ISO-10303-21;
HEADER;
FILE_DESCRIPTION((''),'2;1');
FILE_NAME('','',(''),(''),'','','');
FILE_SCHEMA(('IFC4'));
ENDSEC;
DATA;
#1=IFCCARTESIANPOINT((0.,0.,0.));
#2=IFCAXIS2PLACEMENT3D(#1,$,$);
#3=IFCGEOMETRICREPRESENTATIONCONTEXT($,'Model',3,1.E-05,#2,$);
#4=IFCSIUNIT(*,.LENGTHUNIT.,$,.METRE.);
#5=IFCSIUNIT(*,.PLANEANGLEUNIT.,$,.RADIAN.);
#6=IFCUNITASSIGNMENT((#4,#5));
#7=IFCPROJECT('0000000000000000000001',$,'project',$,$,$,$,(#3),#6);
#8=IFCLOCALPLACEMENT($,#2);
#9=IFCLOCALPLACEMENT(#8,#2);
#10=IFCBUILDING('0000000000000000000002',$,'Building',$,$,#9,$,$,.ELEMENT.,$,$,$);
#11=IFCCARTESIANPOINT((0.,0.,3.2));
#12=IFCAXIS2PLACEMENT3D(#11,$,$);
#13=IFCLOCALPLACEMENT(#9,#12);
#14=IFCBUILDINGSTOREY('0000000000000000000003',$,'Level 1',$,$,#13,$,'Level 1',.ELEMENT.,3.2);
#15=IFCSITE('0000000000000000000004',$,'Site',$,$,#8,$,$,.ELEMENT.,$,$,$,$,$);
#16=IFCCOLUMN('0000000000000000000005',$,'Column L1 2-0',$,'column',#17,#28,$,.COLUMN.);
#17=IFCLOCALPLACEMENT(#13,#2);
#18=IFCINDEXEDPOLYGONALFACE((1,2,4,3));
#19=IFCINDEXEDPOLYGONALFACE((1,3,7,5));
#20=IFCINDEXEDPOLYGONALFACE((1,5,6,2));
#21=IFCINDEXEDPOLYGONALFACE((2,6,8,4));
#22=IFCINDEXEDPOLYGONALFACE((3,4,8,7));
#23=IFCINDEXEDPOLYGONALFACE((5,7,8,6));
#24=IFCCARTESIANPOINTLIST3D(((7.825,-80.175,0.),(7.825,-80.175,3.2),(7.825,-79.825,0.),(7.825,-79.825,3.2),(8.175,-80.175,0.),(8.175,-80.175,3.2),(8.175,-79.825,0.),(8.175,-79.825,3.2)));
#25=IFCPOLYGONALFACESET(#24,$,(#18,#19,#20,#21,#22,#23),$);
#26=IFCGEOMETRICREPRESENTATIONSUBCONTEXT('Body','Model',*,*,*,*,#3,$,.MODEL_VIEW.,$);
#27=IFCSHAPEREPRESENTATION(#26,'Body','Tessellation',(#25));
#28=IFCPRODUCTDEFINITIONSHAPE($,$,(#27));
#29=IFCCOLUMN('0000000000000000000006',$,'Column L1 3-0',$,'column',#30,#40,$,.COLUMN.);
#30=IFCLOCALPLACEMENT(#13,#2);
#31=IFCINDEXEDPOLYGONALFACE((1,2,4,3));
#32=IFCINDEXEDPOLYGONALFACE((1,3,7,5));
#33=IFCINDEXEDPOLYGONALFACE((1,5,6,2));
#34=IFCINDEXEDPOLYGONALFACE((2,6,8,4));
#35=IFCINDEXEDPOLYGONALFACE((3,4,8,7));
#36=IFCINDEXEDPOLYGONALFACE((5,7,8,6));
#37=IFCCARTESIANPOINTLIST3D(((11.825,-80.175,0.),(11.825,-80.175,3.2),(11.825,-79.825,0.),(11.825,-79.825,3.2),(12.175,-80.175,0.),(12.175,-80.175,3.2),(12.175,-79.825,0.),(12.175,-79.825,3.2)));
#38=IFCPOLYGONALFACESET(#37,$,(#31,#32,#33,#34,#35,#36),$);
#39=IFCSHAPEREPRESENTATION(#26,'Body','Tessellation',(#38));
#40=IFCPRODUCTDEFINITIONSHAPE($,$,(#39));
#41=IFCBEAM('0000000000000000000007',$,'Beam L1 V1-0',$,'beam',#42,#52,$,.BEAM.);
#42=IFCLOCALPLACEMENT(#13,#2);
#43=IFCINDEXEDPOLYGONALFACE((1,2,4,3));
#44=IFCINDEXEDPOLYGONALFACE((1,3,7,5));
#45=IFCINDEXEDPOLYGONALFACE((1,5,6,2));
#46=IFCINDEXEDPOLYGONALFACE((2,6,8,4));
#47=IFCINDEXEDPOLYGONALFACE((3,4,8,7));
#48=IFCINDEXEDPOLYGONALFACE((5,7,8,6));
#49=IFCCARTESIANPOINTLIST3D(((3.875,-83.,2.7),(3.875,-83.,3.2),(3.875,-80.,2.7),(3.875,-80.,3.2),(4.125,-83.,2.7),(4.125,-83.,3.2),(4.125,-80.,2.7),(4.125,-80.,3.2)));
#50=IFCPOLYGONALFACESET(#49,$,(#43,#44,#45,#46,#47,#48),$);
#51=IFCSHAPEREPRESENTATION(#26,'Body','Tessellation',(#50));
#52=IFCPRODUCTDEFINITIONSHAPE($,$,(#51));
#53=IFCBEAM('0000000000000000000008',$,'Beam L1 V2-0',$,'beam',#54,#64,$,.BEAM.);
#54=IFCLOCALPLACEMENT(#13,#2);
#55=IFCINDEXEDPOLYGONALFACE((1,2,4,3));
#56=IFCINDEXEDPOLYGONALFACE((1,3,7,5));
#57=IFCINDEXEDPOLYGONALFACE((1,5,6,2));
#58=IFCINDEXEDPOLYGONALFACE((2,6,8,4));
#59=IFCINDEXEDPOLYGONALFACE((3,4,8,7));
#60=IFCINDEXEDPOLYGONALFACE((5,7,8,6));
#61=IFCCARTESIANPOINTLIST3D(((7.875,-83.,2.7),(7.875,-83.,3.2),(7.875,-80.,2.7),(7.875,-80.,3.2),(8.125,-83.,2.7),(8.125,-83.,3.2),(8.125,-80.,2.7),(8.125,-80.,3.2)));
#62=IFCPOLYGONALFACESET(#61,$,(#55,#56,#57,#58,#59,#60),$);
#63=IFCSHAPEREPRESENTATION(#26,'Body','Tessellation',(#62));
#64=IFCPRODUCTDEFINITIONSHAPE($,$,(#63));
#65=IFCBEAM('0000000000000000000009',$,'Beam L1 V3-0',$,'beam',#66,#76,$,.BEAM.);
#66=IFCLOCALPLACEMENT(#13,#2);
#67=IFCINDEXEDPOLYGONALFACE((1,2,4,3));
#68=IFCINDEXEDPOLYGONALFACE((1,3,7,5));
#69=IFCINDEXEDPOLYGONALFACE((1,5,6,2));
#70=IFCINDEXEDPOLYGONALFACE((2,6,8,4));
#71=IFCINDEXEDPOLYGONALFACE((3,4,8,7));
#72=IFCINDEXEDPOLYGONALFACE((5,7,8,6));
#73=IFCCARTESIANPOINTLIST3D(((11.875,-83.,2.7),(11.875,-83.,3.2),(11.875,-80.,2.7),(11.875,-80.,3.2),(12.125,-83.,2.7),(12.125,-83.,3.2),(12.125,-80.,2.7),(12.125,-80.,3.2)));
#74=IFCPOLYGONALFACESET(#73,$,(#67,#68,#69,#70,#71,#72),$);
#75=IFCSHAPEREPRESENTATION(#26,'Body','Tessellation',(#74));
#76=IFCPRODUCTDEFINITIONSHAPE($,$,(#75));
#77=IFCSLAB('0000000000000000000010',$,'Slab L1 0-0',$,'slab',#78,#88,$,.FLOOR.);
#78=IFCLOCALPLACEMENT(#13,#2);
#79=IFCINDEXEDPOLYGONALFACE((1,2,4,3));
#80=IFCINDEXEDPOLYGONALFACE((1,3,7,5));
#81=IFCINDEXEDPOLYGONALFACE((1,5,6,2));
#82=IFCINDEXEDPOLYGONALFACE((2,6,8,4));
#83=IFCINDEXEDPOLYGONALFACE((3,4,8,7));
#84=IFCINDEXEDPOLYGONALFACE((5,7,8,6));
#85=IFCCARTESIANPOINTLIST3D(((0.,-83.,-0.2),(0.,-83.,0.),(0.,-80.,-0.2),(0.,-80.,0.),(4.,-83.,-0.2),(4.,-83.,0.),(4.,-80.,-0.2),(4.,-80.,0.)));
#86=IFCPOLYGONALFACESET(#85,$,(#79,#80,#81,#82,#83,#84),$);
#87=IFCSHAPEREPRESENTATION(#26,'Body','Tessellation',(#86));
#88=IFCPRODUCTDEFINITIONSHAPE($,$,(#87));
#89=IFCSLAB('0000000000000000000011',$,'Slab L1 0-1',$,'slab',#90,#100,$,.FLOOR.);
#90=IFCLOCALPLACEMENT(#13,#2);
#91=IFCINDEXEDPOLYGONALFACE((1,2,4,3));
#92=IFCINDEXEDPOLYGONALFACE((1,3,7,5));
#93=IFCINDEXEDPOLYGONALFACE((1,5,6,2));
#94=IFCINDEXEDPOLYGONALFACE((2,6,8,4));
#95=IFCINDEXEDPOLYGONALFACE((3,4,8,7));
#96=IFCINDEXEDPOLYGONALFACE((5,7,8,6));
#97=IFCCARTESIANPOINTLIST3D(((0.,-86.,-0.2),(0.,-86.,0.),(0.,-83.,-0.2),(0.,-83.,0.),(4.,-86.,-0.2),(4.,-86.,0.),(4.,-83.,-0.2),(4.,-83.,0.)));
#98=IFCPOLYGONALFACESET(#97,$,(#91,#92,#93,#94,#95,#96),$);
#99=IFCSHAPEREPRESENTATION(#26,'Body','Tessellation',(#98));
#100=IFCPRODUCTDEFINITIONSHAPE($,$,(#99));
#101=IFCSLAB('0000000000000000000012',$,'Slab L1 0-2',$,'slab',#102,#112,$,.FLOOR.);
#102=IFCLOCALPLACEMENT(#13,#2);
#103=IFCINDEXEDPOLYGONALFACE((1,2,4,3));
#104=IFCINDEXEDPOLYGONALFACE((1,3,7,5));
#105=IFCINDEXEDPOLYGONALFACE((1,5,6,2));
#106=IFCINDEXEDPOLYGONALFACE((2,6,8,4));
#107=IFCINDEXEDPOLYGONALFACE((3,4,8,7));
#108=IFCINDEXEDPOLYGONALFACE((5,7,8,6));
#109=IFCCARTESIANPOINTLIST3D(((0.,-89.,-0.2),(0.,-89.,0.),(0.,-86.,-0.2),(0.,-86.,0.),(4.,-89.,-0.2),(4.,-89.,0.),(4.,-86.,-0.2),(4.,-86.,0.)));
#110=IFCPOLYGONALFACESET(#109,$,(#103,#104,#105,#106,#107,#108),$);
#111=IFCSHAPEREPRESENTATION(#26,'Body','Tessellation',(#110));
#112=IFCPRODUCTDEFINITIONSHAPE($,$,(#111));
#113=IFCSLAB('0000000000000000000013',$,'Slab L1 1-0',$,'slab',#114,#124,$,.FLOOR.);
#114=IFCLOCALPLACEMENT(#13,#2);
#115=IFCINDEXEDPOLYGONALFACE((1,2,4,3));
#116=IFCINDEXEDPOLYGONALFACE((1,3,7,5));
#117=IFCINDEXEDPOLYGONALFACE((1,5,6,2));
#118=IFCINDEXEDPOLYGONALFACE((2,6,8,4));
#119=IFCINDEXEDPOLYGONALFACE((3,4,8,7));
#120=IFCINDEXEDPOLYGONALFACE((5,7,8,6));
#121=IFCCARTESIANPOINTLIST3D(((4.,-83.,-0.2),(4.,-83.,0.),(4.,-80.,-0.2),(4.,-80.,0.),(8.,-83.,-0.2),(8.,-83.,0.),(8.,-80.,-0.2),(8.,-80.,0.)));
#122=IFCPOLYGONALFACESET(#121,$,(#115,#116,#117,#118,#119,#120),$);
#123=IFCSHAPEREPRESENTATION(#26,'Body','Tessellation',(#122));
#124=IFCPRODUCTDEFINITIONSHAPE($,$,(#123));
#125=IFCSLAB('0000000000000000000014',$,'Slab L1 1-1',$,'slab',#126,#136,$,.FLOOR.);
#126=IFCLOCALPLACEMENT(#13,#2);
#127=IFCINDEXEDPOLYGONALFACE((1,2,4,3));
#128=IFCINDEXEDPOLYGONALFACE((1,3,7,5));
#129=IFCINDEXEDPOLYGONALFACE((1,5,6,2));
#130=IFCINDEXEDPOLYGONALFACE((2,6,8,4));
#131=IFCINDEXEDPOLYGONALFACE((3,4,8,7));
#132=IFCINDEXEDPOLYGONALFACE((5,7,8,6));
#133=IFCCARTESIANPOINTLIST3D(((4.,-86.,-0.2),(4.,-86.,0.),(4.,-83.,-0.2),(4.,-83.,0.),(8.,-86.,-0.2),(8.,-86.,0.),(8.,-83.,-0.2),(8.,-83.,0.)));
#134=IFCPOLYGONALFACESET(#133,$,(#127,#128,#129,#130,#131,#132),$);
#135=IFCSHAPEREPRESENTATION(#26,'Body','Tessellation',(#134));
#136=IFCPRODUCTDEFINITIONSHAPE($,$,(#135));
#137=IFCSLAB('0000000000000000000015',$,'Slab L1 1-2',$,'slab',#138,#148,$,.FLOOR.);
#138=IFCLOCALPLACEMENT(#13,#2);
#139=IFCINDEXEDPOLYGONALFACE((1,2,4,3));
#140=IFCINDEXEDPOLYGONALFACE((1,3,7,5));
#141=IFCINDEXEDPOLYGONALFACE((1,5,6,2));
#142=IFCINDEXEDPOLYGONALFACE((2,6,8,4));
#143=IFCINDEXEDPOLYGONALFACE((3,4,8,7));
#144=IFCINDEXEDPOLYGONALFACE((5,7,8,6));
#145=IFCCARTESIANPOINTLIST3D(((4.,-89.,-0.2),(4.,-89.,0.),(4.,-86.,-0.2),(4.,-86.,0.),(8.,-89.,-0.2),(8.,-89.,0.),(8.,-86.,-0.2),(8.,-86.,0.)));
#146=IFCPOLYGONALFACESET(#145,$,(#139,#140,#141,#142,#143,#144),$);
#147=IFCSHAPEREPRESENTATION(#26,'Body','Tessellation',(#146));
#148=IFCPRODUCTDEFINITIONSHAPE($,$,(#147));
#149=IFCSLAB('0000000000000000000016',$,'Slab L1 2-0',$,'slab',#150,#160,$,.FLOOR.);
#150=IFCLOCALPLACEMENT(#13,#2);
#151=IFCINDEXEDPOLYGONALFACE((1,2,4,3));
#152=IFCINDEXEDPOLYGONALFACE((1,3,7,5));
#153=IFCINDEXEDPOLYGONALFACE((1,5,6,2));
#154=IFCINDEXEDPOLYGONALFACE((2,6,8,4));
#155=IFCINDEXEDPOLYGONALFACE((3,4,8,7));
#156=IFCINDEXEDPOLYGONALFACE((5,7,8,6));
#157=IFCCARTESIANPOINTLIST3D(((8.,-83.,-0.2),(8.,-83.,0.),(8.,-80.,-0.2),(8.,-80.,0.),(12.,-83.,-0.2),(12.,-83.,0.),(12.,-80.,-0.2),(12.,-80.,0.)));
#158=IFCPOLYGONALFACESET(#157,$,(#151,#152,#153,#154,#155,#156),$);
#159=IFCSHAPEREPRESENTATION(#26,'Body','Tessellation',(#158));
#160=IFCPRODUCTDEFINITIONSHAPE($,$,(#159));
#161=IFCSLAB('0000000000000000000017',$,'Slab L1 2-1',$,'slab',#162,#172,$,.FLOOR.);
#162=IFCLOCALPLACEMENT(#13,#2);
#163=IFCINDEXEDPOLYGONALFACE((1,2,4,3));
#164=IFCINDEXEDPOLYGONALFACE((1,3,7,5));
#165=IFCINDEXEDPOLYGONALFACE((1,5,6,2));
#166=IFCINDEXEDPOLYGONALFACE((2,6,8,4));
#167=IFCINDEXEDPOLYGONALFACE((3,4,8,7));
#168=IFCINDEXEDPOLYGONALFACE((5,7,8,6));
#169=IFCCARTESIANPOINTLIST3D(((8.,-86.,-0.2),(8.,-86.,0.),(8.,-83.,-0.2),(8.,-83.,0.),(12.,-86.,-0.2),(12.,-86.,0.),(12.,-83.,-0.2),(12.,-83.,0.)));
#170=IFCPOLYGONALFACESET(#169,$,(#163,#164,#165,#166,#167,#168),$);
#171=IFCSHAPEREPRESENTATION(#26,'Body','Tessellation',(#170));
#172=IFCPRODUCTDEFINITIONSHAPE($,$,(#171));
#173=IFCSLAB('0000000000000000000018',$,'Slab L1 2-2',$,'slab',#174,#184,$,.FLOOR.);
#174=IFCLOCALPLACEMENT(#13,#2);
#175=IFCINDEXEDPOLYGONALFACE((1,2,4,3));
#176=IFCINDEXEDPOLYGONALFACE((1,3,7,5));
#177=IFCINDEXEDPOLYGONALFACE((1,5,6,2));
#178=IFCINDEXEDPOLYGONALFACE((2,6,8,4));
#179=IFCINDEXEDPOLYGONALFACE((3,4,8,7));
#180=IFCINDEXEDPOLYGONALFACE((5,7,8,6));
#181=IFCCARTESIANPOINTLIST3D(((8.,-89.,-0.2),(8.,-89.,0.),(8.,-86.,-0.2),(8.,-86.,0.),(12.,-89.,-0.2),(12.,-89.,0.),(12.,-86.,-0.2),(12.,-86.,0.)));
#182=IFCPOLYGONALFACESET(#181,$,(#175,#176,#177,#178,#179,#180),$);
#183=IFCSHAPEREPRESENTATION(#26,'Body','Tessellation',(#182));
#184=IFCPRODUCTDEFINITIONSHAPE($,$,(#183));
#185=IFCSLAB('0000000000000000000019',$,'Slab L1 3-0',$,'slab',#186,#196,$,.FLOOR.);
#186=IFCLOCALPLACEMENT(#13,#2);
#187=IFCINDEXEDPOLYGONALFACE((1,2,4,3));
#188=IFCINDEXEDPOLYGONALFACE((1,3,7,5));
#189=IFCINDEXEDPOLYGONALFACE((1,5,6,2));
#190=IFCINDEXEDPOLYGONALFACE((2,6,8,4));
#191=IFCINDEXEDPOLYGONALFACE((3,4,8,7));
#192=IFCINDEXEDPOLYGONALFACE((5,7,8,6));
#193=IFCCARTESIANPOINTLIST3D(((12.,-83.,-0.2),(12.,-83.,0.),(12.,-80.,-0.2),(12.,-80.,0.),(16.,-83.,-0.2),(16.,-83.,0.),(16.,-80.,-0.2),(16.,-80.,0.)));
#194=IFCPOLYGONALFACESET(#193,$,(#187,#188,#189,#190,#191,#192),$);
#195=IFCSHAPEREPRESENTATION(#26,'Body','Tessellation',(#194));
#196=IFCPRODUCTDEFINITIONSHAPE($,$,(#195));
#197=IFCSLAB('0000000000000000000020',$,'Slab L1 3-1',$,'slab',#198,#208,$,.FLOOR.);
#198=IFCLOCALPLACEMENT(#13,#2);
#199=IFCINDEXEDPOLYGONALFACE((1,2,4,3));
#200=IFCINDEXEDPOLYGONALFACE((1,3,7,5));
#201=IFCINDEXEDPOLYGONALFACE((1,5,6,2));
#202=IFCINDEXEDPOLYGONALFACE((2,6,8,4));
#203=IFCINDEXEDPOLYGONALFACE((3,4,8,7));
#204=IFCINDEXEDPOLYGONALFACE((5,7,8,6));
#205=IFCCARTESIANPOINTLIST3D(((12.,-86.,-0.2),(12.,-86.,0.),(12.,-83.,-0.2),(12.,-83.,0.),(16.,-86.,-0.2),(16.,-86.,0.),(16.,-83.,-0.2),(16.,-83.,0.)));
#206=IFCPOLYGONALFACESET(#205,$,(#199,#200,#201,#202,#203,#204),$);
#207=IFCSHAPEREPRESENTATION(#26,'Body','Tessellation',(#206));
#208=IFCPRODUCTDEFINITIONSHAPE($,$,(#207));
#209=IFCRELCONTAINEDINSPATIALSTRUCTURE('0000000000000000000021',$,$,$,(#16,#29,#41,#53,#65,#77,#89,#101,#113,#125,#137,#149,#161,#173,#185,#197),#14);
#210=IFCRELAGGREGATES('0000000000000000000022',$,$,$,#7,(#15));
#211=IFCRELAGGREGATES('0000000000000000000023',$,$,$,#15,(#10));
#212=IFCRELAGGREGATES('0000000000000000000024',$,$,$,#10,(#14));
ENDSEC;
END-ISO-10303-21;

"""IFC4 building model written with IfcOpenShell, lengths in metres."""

from ifc_helpers import new_model, si_unit, frame, origin, origin_2d, place, context, subcontext, project, spatial, polyline, rectangle, outline, extrude, element, save


model = new_model("IFC4")

# Units and contexts
model_context = context("Model", 3, precision=1e-05, world=origin())
body_context = subcontext(model_context, "Body", "Model", "MODEL_VIEW")
ifc_project = project(units=[si_unit("LENGTHUNIT", "METRE"), si_unit("PLANEANGLEUNIT", "RADIAN")], contexts=[model_context])

# Site, building, storey
site_placement = place(None, origin())
site = spatial("IfcSite", under=ifc_project, at=site_placement, Name="Site", CompositionType="ELEMENT")
building_placement = place(site_placement, origin())
building = spatial("IfcBuilding", under=site, at=building_placement, Name="Building", CompositionType="ELEMENT")
storey_placement = place(building_placement, frame((0.0, 0.0, 3.2)))
storey = spatial("IfcBuildingStorey", under=building, at=storey_placement, Name="Level 1", LongName="Level 1", CompositionType="ELEMENT", Elevation=3.2)

# Columns
for number, where, name in (
    (1, (8.0, -80.0, 0.0), "Column L1 2-0"),
    (2, (12.0, -80.0, 0.0), "Column L1 3-0"),
):
    element("IfcColumn", number, at=place(storey_placement, frame(where)), inside=storey, Name=name, ObjectType="column", PredefinedType="COLUMN", context=body_context, shape_type="SweptSolid", body=[
        extrude(rectangle(XDim=0.35, YDim=0.35, at=origin_2d()), origin(), (0.0, 0.0, 1.0), 3.2),
    ])

# Beams
for number, where, z_axis, x_axis, name in (
    (3, (4.0, -80.0, 2.95), (0.0, -1.0, 0.0), (0.0, 0.0, 1.0), "Beam L1 V1-0"),
    (4, (8.0, -80.0, 2.95), (0.0, -1.0, 0.0), (0.0, 0.0, 1.0), "Beam L1 V2-0"),
    (5, (12.0, -80.0, 2.95), (0.0, -1.0, 0.0), (0.0, 0.0, 1.0), "Beam L1 V3-0"),
):
    element("IfcBeam", number, at=place(storey_placement, frame(where, z_axis=z_axis, x_axis=x_axis)), inside=storey, Name=name, ObjectType="beam", PredefinedType="BEAM", context=body_context, shape_type="SweptSolid", body=[
        extrude(rectangle(XDim=0.5, YDim=0.25, at=origin_2d()), origin(), (0.0, 0.0, 1.0), 3.0),
    ])

# Slabs
slab_1_placement = place(storey_placement, frame((0.0, 0.0, -0.2)))
element("IfcSlab", 6, at=slab_1_placement, inside=storey, Name="Slab L1 0-0", ObjectType="slab", PredefinedType="FLOOR", context=body_context, shape_type="SweptSolid", body=[
    extrude(outline(polyline([(0.0, -83.0), (4.0, -83.0), (4.0, -80.0), (0.0, -80.0), (0.0, -83.0)])), origin(), (0.0, 0.0, 1.0), 0.2),
])
slab_2_placement = place(storey_placement, frame((0.0, 0.0, -0.2)))
element("IfcSlab", 7, at=slab_2_placement, inside=storey, Name="Slab L1 0-1", ObjectType="slab", PredefinedType="FLOOR", context=body_context, shape_type="SweptSolid", body=[
    extrude(outline(polyline([(0.0, -86.0), (4.0, -86.0), (4.0, -83.0), (0.0, -83.0), (0.0, -86.0)])), origin(), (0.0, 0.0, 1.0), 0.2),
])
slab_3_placement = place(storey_placement, frame((0.0, 0.0, -0.2)))
element("IfcSlab", 8, at=slab_3_placement, inside=storey, Name="Slab L1 0-2", ObjectType="slab", PredefinedType="FLOOR", context=body_context, shape_type="SweptSolid", body=[
    extrude(outline(polyline([(0.0, -89.0), (4.0, -89.0), (4.0, -86.0), (0.0, -86.0), (0.0, -89.0)])), origin(), (0.0, 0.0, 1.0), 0.2),
])
slab_4_placement = place(storey_placement, frame((0.0, 0.0, -0.2)))
element("IfcSlab", 9, at=slab_4_placement, inside=storey, Name="Slab L1 1-0", ObjectType="slab", PredefinedType="FLOOR", context=body_context, shape_type="SweptSolid", body=[
    extrude(outline(polyline([(4.0, -83.0), (8.0, -83.0), (8.0, -80.0), (4.0, -80.0), (4.0, -83.0)])), origin(), (0.0, 0.0, 1.0), 0.2),
])
slab_5_placement = place(storey_placement, frame((0.0, 0.0, -0.2)))
element("IfcSlab", 10, at=slab_5_placement, inside=storey, Name="Slab L1 1-1", ObjectType="slab", PredefinedType="FLOOR", context=body_context, shape_type="SweptSolid", body=[
    extrude(outline(polyline([(4.0, -86.0), (8.0, -86.0), (8.0, -83.0), (4.0, -83.0), (4.0, -86.0)])), origin(), (0.0, 0.0, 1.0), 0.2),
])
slab_6_placement = place(storey_placement, frame((0.0, 0.0, -0.2)))
element("IfcSlab", 11, at=slab_6_placement, inside=storey, Name="Slab L1 1-2", ObjectType="slab", PredefinedType="FLOOR", context=body_context, shape_type="SweptSolid", body=[
    extrude(outline(polyline([(4.0, -89.0), (8.0, -89.0), (8.0, -86.0), (4.0, -86.0), (4.0, -89.0)])), origin(), (0.0, 0.0, 1.0), 0.2),
])
slab_7_placement = place(storey_placement, frame((0.0, 0.0, -0.2)))
element("IfcSlab", 12, at=slab_7_placement, inside=storey, Name="Slab L1 2-0", ObjectType="slab", PredefinedType="FLOOR", context=body_context, shape_type="SweptSolid", body=[
    extrude(outline(polyline([(8.0, -83.0), (12.0, -83.0), (12.0, -80.0), (8.0, -80.0), (8.0, -83.0)])), origin(), (0.0, 0.0, 1.0), 0.2),
])
slab_8_placement = place(storey_placement, frame((0.0, 0.0, -0.2)))
element("IfcSlab", 13, at=slab_8_placement, inside=storey, Name="Slab L1 2-1", ObjectType="slab", PredefinedType="FLOOR", context=body_context, shape_type="SweptSolid", body=[
    extrude(outline(polyline([(8.0, -86.0), (12.0, -86.0), (12.0, -83.0), (8.0, -83.0), (8.0, -86.0)])), origin(), (0.0, 0.0, 1.0), 0.2),
])
slab_9_placement = place(storey_placement, frame((0.0, 0.0, -0.2)))
element("IfcSlab", 14, at=slab_9_placement, inside=storey, Name="Slab L1 2-2", ObjectType="slab", PredefinedType="FLOOR", context=body_context, shape_type="SweptSolid", body=[
    extrude(outline(polyline([(8.0, -89.0), (12.0, -89.0), (12.0, -86.0), (8.0, -86.0), (8.0, -89.0)])), origin(), (0.0, 0.0, 1.0), 0.2),
])
slab_10_placement = place(storey_placement, frame((0.0, 0.0, -0.2)))
element("IfcSlab", 15, at=slab_10_placement, inside=storey, Name="Slab L1 3-0", ObjectType="slab", PredefinedType="FLOOR", context=body_context, shape_type="SweptSolid", body=[
    extrude(outline(polyline([(12.0, -83.0), (16.0, -83.0), (16.0, -80.0), (12.0, -80.0), (12.0, -83.0)])), origin(), (0.0, 0.0, 1.0), 0.2),
])
slab_11_placement = place(storey_placement, frame((0.0, 0.0, -0.2)))
element("IfcSlab", 16, at=slab_11_placement, inside=storey, Name="Slab L1 3-1", ObjectType="slab", PredefinedType="FLOOR", context=body_context, shape_type="SweptSolid", body=[
    extrude(outline(polyline([(12.0, -86.0), (16.0, -86.0), (16.0, -83.0), (12.0, -83.0), (12.0, -86.0)])), origin(), (0.0, 0.0, 1.0), 0.2),
])

save(model, "model.ifc")
